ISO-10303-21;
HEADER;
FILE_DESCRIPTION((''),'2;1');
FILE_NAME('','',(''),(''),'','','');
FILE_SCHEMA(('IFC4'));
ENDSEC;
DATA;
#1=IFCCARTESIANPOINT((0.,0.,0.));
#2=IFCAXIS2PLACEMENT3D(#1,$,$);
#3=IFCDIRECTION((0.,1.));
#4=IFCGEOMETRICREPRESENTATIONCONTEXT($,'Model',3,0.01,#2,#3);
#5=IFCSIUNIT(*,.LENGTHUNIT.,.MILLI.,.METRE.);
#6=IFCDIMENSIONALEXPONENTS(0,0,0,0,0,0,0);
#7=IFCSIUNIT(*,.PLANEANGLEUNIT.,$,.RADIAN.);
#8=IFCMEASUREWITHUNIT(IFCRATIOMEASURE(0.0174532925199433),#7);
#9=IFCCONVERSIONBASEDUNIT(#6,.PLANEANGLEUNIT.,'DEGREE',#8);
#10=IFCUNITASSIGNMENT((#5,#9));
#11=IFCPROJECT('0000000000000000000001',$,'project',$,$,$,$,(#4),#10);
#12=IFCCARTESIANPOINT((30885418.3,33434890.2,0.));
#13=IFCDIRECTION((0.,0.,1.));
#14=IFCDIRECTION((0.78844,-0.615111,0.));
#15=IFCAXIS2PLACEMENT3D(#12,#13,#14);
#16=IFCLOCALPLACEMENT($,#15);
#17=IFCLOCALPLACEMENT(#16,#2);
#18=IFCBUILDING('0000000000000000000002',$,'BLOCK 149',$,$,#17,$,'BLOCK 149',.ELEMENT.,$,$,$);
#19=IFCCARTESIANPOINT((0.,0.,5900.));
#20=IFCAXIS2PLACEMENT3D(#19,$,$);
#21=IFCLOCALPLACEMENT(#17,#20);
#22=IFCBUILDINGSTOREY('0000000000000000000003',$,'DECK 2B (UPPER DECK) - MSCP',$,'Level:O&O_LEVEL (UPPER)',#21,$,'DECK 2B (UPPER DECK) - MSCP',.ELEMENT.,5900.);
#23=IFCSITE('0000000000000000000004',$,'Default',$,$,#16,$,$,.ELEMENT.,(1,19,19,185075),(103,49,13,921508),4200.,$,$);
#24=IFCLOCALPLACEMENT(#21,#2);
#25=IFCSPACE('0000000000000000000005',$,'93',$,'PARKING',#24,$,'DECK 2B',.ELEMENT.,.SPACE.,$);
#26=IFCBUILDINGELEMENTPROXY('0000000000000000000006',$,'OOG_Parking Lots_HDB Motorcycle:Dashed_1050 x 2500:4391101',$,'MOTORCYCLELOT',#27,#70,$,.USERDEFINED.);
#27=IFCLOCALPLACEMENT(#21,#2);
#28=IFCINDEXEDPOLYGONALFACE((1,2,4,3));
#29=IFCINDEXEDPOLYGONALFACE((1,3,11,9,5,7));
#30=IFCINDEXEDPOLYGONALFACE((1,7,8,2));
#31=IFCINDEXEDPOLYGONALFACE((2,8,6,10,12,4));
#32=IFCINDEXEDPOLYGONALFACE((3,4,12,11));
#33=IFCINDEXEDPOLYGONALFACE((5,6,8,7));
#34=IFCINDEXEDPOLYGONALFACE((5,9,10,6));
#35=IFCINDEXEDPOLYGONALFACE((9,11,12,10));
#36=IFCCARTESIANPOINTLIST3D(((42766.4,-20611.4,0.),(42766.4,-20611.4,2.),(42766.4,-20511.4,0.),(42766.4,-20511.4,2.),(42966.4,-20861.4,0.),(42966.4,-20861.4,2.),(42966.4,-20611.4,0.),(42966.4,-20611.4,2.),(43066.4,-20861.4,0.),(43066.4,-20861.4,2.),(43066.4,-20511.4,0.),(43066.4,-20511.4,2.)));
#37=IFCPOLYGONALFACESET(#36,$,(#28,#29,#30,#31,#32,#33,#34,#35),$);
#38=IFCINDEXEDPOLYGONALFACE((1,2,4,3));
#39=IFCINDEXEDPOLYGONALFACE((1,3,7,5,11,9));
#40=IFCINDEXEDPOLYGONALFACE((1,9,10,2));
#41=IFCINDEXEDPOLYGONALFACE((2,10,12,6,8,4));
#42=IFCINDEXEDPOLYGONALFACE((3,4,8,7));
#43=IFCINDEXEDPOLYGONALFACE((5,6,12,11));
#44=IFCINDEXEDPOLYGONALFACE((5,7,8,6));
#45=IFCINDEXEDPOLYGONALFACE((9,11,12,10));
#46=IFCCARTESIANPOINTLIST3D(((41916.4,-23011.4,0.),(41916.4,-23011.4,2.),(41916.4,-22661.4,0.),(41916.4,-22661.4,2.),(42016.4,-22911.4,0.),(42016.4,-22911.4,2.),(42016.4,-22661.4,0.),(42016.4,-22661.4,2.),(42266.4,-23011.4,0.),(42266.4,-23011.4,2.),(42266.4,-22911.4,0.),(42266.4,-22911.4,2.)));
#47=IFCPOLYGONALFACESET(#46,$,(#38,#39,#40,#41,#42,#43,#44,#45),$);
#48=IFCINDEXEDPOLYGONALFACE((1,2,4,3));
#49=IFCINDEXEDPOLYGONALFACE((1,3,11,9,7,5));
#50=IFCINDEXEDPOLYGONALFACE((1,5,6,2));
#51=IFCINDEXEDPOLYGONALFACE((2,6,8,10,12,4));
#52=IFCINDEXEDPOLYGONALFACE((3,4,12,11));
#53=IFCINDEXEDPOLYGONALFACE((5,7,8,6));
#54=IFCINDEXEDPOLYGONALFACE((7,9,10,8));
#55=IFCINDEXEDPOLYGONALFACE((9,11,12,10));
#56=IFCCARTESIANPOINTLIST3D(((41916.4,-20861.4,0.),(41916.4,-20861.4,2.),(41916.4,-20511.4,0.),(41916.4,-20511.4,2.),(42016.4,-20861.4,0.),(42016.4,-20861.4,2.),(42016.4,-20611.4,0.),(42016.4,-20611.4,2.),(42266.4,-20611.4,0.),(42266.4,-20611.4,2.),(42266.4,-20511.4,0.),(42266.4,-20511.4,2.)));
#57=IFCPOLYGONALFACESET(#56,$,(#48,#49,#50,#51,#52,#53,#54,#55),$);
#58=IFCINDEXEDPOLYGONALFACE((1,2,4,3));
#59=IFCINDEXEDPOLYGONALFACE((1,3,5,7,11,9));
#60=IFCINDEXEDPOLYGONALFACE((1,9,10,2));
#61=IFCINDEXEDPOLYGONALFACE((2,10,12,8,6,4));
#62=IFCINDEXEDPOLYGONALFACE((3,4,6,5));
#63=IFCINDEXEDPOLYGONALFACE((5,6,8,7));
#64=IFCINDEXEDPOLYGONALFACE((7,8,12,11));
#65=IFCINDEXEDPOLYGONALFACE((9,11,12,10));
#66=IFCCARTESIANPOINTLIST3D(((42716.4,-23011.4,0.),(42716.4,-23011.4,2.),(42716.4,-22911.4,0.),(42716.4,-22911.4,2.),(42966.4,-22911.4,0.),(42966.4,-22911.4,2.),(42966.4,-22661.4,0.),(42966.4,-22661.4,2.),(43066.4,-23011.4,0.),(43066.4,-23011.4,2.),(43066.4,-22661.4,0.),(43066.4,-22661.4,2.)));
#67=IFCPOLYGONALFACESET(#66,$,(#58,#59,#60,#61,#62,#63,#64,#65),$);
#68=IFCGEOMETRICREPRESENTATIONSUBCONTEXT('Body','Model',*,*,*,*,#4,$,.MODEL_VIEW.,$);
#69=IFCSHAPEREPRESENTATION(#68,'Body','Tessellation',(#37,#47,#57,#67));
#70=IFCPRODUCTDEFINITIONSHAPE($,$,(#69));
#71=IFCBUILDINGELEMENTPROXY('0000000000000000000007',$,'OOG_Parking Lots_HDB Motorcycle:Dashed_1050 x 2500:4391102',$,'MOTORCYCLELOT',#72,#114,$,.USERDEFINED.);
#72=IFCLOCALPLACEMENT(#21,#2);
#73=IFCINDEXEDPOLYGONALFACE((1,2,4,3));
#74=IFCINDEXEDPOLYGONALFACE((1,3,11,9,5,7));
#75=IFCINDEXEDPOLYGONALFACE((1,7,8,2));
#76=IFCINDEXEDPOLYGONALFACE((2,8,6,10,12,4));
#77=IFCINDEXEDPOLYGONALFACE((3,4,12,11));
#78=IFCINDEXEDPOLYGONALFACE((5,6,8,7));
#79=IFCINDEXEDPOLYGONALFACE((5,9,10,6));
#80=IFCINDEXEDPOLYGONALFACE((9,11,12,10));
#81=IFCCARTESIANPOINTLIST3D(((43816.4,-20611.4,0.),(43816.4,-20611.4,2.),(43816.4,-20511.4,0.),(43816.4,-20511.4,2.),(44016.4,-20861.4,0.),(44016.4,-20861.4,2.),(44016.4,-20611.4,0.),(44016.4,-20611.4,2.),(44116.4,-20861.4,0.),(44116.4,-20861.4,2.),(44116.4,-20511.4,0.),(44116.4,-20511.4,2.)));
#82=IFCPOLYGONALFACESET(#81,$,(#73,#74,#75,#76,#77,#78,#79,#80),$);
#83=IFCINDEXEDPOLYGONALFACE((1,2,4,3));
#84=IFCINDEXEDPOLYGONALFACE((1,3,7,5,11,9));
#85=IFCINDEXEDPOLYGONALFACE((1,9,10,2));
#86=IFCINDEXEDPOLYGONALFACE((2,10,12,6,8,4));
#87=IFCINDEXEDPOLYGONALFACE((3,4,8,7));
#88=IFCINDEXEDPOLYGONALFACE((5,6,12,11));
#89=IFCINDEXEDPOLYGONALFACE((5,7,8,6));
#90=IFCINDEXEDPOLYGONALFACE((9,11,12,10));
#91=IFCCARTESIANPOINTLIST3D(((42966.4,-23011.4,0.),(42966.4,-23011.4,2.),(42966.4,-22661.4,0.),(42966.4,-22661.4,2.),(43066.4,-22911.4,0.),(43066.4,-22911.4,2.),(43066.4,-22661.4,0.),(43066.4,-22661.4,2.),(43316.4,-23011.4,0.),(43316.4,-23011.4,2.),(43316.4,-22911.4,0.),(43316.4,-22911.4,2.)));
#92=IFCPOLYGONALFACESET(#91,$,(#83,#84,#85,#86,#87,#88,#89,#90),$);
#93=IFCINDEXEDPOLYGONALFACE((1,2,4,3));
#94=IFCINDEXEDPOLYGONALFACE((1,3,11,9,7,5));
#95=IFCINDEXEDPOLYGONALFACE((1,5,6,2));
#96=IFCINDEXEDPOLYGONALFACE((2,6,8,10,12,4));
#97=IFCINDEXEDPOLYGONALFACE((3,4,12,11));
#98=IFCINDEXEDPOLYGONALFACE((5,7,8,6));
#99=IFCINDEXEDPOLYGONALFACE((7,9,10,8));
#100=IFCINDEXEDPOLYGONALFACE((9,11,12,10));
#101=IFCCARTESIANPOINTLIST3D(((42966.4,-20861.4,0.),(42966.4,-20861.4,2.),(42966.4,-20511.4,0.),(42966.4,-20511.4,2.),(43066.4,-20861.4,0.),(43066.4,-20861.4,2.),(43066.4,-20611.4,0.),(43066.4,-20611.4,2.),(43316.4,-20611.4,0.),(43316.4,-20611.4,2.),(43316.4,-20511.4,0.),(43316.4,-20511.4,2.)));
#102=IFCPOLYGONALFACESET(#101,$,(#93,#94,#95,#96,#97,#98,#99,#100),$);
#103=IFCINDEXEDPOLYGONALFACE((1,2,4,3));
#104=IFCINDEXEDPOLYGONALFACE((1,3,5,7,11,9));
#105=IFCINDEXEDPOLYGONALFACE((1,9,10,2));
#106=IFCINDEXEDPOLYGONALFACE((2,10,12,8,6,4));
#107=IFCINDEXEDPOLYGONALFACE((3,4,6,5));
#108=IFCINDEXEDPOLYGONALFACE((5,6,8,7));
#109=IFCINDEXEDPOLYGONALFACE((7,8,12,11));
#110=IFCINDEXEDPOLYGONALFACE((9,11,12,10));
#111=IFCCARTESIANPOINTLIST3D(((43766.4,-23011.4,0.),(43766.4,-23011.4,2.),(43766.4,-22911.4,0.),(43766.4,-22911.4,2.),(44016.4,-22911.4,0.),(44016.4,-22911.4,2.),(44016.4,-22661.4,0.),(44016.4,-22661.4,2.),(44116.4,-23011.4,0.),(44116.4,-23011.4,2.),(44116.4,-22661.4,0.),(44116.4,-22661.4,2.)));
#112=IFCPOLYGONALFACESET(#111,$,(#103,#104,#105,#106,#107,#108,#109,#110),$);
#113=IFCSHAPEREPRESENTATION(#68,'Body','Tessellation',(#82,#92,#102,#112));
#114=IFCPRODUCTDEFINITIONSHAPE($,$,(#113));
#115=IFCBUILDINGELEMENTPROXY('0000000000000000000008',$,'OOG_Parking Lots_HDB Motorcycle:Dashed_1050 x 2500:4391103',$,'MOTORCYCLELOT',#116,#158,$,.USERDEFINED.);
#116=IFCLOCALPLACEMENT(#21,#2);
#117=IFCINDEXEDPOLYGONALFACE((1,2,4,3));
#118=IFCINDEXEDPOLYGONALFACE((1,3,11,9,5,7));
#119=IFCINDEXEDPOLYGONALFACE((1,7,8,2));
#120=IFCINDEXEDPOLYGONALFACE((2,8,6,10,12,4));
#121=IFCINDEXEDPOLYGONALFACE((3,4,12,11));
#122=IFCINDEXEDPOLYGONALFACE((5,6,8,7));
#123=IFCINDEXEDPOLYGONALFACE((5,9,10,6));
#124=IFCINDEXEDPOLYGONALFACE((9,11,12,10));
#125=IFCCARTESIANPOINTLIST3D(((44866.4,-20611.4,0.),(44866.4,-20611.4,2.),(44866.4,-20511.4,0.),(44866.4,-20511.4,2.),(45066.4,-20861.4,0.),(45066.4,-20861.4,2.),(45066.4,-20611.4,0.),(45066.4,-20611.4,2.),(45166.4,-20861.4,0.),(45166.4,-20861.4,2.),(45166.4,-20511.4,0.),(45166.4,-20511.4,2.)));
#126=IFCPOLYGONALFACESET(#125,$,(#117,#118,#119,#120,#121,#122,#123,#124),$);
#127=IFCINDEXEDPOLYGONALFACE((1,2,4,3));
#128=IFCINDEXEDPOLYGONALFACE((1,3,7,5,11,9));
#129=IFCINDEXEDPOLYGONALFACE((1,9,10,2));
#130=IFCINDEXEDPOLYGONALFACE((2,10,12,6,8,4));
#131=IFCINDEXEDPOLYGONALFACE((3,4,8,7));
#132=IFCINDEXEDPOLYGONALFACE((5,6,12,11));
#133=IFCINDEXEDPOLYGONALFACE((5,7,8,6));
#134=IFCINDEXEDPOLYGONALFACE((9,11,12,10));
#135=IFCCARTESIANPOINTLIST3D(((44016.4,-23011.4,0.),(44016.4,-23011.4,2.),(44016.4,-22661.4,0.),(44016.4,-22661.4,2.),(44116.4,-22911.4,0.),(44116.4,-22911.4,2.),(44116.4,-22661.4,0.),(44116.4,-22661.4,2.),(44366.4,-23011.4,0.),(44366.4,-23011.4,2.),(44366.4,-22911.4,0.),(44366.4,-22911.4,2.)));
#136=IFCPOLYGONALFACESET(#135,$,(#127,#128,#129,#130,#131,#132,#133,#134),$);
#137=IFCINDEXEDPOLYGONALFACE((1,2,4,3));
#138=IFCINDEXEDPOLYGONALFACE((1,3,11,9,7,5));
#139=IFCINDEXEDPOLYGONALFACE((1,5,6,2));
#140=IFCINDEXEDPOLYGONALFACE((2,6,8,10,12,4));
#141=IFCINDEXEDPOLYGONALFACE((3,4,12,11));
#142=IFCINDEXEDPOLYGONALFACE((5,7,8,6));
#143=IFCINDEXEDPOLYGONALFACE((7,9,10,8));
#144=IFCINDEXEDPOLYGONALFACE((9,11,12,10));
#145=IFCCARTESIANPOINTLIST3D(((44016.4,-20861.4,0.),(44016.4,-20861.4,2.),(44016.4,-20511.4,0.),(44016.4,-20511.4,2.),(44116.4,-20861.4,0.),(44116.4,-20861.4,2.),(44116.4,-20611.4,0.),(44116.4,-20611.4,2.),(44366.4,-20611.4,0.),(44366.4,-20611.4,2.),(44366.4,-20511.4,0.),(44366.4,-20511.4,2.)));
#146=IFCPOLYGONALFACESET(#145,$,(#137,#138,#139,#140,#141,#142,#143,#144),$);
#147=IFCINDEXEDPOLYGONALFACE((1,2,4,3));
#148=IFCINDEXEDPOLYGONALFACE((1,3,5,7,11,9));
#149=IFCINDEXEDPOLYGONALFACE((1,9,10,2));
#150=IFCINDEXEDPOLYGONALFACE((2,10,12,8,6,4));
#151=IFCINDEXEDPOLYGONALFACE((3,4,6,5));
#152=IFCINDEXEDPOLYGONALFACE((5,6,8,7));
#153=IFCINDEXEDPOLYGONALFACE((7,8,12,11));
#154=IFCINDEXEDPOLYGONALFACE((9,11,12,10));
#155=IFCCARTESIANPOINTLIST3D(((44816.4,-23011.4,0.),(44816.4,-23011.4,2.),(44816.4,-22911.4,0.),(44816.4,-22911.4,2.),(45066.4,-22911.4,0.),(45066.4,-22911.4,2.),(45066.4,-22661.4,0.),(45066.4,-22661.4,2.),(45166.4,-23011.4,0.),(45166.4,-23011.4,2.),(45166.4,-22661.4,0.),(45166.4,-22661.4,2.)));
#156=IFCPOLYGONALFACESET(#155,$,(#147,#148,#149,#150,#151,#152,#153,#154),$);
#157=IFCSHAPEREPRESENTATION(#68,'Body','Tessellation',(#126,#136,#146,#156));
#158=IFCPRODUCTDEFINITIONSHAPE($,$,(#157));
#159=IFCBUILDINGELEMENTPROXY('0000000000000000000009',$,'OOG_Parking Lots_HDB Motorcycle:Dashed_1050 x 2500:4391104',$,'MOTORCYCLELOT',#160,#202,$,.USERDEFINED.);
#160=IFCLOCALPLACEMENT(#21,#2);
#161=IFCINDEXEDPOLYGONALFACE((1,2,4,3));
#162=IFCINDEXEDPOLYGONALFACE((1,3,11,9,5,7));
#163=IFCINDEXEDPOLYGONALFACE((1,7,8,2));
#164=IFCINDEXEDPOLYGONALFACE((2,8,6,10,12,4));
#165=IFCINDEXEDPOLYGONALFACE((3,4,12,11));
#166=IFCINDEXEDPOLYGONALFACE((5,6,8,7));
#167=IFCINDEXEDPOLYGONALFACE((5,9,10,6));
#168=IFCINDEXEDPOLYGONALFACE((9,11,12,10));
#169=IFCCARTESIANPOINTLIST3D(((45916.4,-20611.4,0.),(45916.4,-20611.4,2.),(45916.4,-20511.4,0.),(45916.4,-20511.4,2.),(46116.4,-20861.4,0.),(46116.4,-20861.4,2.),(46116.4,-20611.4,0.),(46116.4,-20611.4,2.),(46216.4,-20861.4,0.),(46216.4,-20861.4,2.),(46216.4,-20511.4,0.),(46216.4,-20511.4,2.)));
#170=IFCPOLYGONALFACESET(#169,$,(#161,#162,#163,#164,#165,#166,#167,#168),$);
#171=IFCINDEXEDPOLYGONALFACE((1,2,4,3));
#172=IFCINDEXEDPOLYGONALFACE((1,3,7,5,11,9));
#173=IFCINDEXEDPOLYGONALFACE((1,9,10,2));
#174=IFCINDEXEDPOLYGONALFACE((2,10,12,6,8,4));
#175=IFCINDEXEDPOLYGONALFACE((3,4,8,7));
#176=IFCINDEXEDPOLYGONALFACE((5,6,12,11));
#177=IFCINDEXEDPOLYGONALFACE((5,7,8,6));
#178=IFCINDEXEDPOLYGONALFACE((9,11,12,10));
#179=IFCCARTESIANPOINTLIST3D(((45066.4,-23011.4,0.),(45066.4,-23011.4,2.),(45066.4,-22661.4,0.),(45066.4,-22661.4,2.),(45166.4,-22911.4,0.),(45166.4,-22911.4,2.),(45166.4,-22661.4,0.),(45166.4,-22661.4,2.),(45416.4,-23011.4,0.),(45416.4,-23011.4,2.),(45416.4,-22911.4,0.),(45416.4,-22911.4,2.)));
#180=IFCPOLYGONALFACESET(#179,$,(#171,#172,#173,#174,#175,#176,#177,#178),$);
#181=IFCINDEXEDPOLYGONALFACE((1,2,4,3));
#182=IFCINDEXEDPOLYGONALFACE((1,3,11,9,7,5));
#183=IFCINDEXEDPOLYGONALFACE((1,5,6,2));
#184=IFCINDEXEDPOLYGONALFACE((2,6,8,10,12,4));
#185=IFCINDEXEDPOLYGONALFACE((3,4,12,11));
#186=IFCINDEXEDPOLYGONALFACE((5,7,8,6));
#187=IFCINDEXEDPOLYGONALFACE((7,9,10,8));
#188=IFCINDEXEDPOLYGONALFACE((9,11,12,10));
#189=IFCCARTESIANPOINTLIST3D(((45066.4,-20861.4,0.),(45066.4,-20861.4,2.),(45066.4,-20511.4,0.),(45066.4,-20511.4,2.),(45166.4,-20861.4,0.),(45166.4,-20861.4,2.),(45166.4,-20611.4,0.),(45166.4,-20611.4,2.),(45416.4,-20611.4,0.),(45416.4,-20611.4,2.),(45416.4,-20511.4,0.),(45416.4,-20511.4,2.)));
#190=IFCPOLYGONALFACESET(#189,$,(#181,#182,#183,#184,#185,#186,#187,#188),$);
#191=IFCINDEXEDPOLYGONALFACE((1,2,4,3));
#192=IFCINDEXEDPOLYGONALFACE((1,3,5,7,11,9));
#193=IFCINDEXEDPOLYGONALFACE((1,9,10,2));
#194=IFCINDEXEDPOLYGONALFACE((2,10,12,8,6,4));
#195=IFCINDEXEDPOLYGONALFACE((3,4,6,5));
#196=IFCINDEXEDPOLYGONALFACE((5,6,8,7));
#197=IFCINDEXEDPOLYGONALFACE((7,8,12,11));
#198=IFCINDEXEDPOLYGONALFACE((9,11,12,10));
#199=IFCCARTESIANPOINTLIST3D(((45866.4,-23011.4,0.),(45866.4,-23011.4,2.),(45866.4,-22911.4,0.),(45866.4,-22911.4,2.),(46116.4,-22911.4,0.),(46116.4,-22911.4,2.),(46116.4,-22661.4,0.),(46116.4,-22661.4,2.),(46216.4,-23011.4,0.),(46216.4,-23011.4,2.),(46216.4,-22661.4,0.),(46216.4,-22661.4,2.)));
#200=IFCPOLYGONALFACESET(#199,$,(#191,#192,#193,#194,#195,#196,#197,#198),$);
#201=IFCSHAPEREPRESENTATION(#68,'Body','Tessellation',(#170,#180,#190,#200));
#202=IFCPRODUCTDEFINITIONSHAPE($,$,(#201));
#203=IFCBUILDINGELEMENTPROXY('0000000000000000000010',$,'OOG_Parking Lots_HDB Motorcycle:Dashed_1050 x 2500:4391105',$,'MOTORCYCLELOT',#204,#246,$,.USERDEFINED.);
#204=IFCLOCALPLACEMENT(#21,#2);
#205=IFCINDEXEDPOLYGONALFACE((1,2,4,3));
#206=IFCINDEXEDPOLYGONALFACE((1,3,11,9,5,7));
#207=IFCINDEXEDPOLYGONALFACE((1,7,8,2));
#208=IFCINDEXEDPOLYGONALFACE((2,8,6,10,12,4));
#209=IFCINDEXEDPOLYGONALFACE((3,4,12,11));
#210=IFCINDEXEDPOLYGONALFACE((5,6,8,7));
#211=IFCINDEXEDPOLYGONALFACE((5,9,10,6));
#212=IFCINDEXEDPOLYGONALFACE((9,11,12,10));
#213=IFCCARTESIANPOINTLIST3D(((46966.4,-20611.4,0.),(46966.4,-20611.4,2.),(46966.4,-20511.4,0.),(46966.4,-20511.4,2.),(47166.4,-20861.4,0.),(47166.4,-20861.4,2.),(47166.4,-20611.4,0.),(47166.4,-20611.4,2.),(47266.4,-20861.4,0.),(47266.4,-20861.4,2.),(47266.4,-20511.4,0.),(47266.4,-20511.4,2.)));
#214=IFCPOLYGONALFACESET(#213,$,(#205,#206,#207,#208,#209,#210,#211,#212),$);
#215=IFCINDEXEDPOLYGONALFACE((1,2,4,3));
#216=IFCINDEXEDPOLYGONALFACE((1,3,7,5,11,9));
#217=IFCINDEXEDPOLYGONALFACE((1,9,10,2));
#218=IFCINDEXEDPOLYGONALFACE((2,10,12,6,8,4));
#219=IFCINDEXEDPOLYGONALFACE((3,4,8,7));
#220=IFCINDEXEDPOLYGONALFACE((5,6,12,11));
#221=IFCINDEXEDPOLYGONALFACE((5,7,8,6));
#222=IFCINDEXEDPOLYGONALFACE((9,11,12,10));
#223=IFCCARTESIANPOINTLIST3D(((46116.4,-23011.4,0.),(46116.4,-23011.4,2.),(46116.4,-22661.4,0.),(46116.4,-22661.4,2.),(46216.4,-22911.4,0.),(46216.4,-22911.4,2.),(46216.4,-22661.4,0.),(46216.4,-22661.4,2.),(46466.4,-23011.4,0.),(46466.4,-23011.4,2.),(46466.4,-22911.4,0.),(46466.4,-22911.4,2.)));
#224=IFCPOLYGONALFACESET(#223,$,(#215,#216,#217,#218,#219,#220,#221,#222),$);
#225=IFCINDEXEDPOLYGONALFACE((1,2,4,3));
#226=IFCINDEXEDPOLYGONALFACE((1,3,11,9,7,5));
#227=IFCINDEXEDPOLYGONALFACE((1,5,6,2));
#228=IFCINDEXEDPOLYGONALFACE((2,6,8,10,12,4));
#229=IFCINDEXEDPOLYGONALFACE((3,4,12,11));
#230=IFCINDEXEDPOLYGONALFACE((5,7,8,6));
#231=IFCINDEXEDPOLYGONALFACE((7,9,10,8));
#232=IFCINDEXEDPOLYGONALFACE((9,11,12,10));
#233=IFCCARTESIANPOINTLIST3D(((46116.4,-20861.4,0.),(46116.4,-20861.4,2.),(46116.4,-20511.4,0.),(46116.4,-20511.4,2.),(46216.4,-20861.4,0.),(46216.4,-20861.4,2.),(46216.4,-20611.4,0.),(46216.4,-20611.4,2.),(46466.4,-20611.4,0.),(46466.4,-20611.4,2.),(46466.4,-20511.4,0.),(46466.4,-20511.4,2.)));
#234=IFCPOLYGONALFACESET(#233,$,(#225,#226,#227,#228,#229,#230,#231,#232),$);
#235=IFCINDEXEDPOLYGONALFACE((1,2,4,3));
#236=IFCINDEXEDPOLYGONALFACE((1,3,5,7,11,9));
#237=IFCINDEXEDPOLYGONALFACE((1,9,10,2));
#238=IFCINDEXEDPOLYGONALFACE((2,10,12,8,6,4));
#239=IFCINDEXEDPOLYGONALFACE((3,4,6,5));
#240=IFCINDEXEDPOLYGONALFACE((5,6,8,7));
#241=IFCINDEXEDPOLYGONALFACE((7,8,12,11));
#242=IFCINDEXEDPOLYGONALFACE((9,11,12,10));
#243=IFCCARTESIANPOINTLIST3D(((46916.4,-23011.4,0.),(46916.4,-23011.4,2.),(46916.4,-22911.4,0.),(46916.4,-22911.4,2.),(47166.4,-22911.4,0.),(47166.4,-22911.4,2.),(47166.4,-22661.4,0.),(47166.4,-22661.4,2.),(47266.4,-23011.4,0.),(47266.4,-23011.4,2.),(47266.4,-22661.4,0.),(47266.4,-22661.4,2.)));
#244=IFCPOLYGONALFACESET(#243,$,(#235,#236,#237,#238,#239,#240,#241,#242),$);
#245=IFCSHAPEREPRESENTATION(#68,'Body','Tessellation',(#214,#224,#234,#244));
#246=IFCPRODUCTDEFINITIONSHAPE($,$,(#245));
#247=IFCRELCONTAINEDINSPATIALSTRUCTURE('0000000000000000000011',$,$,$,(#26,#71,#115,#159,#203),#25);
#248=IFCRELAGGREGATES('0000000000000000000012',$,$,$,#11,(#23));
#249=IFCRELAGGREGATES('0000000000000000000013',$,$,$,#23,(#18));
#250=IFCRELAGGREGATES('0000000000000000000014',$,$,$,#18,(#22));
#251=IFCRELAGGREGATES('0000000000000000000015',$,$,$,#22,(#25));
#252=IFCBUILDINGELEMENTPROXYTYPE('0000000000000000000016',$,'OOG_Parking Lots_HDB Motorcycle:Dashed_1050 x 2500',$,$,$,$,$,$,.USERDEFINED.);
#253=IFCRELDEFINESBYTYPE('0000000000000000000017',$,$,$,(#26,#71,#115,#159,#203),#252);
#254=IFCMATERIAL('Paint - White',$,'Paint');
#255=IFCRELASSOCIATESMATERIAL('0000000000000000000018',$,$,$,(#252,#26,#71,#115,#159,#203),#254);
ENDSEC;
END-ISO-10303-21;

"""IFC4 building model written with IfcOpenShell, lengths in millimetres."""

from ifc_helpers import new_model, entity, si_unit, converted_unit, direction, frame, origin, place, context, subcontext, project, spatial, indexed_curve, outline, extrude, source, transform, mapped, material, type_object, type_shapes, element, save


model = new_model("IFC4")

# Units and contexts
model_context = context("Model", 3, precision=0.01, world=origin(), true_north=direction((0.0, 1.0)))
body_context = subcontext(model_context, "Body", "Model", "MODEL_VIEW")
ifc_project = project(units=[si_unit("LENGTHUNIT", "METRE", prefix="MILLI"), converted_unit("PLANEANGLEUNIT", "DEGREE", entity("IfcRatioMeasure", 0.0174532925199433), si_unit("PLANEANGLEUNIT", "RADIAN"), dimensions=[0, 0, 0, 0, 0, 0, 0])], contexts=[model_context])

# Site, building, storey
site_placement = place(None, frame((30885418.3, 33434890.2, 0.0), z_axis=(0.0, 0.0, 1.0), x_axis=(0.78844, -0.615111, 0.0)))
site = spatial("IfcSite", under=ifc_project, at=site_placement, Name="Default", CompositionType="ELEMENT", RefLatitude=(1, 19, 19, 185075), RefLongitude=(103, 49, 13, 921508), RefElevation=4200.0)
building_placement = place(site_placement, origin())
building = spatial("IfcBuilding", under=site, at=building_placement, Name="BLOCK 149", LongName="BLOCK 149", CompositionType="ELEMENT")
storey_placement = place(building_placement, frame((0.0, 0.0, 5900.0)))
storey = spatial("IfcBuildingStorey", under=building, at=storey_placement, Name="DECK 2B (UPPER DECK) - MSCP", ObjectType="Level:O&O_LEVEL (UPPER)", LongName="DECK 2B (UPPER DECK) - MSCP", CompositionType="ELEMENT", Elevation=5900.0)

# Shared definitions
space_placement = place(storey_placement, origin())
space = spatial("IfcSpace", under=storey, at=space_placement, Name="93", ObjectType="PARKING", LongName="DECK 2B", CompositionType="ELEMENT", PredefinedType="SPACE")

# Building element proxies
ifc_material_1 = material(Name="Paint - White", Category="Paint")
building_element_proxy_type_1 = type_object("IfcBuildingElementProxyType", Name="OOG_Parking Lots_HDB Motorcycle:Dashed_1050 x 2500", PredefinedType="USERDEFINED", material=ifc_material_1)
shared_shape_1 = source(origin(), body_context, "Body", "SweptSolid", [
    extrude(outline(indexed_curve([(-200.0, -133.3), (150.0, -133.3), (150.0, 166.7), (50.0, 166.7), (50.0, -33.3), (-200.0, -33.3), (-200.0, -133.3)], self_intersect=False)), frame((966.7, -100.0, 0.0), z_axis=(0.0, 0.0, 1.0), x_axis=(0.0, 1.0, 0.0)), (0.0, 0.0, 1.0), 2.0),
    extrude(outline(indexed_curve([(-200.0, -150.0), (150.0, -150.0), (150.0, 200.0), (50.0, 200.0), (50.0, -50.0), (-200.0, -50.0), (-200.0, -150.0)], self_intersect=False)), frame((100.0, -2300.0, 0.0), z_axis=(0.0, 0.0, 1.0), x_axis=(0.0, -1.0, 0.0)), (0.0, 0.0, 1.0), 2.0),
    extrude(outline(indexed_curve([(-200.0, -150.0), (150.0, -150.0), (150.0, 200.0), (50.0, 200.0), (50.0, -50.0), (-200.0, -50.0), (-200.0, -150.0)], self_intersect=False)), frame((100.0, -100.0, 0.0), z_axis=(0.0, 0.0, 1.0), x_axis=(-1.0, 0.0, 0.0)), (0.0, 0.0, 1.0), 2.0),
    extrude(outline(indexed_curve([(-200.0, -150.0), (150.0, -150.0), (150.0, 200.0), (50.0, 200.0), (50.0, -50.0), (-200.0, -50.0), (-200.0, -150.0)], self_intersect=False)), frame((950.0, -2300.0, 0.0)), (0.0, 0.0, 1.0), 2.0),
])
type_shapes(building_element_proxy_type_1, [shared_shape_1])
for number, where, name in (
    (1, (41966.4, -20561.4, 0.0), "OOG_Parking Lots_HDB Motorcycle:Dashed_1050 x 2500:4391101"),
    (2, (43016.4, -20561.4, 0.0), "OOG_Parking Lots_HDB Motorcycle:Dashed_1050 x 2500:4391102"),
    (3, (44066.4, -20561.4, 0.0), "OOG_Parking Lots_HDB Motorcycle:Dashed_1050 x 2500:4391103"),
    (4, (45116.4, -20561.4, 0.0), "OOG_Parking Lots_HDB Motorcycle:Dashed_1050 x 2500:4391104"),
    (5, (46166.4, -20561.4, 0.0), "OOG_Parking Lots_HDB Motorcycle:Dashed_1050 x 2500:4391105"),
):
    element("IfcBuildingElementProxy", number, at=place(space_placement, frame(where)), inside=space, type_object=building_element_proxy_type_1, material=ifc_material_1, Name=name, ObjectType="MOTORCYCLELOT", PredefinedType="USERDEFINED", context=body_context, shape_type="MappedRepresentation", body=[
        mapped(shared_shape_1, transform((0.0, 0.0, 0.0), scale=1.0)),
    ])

save(model, "model.ifc")
